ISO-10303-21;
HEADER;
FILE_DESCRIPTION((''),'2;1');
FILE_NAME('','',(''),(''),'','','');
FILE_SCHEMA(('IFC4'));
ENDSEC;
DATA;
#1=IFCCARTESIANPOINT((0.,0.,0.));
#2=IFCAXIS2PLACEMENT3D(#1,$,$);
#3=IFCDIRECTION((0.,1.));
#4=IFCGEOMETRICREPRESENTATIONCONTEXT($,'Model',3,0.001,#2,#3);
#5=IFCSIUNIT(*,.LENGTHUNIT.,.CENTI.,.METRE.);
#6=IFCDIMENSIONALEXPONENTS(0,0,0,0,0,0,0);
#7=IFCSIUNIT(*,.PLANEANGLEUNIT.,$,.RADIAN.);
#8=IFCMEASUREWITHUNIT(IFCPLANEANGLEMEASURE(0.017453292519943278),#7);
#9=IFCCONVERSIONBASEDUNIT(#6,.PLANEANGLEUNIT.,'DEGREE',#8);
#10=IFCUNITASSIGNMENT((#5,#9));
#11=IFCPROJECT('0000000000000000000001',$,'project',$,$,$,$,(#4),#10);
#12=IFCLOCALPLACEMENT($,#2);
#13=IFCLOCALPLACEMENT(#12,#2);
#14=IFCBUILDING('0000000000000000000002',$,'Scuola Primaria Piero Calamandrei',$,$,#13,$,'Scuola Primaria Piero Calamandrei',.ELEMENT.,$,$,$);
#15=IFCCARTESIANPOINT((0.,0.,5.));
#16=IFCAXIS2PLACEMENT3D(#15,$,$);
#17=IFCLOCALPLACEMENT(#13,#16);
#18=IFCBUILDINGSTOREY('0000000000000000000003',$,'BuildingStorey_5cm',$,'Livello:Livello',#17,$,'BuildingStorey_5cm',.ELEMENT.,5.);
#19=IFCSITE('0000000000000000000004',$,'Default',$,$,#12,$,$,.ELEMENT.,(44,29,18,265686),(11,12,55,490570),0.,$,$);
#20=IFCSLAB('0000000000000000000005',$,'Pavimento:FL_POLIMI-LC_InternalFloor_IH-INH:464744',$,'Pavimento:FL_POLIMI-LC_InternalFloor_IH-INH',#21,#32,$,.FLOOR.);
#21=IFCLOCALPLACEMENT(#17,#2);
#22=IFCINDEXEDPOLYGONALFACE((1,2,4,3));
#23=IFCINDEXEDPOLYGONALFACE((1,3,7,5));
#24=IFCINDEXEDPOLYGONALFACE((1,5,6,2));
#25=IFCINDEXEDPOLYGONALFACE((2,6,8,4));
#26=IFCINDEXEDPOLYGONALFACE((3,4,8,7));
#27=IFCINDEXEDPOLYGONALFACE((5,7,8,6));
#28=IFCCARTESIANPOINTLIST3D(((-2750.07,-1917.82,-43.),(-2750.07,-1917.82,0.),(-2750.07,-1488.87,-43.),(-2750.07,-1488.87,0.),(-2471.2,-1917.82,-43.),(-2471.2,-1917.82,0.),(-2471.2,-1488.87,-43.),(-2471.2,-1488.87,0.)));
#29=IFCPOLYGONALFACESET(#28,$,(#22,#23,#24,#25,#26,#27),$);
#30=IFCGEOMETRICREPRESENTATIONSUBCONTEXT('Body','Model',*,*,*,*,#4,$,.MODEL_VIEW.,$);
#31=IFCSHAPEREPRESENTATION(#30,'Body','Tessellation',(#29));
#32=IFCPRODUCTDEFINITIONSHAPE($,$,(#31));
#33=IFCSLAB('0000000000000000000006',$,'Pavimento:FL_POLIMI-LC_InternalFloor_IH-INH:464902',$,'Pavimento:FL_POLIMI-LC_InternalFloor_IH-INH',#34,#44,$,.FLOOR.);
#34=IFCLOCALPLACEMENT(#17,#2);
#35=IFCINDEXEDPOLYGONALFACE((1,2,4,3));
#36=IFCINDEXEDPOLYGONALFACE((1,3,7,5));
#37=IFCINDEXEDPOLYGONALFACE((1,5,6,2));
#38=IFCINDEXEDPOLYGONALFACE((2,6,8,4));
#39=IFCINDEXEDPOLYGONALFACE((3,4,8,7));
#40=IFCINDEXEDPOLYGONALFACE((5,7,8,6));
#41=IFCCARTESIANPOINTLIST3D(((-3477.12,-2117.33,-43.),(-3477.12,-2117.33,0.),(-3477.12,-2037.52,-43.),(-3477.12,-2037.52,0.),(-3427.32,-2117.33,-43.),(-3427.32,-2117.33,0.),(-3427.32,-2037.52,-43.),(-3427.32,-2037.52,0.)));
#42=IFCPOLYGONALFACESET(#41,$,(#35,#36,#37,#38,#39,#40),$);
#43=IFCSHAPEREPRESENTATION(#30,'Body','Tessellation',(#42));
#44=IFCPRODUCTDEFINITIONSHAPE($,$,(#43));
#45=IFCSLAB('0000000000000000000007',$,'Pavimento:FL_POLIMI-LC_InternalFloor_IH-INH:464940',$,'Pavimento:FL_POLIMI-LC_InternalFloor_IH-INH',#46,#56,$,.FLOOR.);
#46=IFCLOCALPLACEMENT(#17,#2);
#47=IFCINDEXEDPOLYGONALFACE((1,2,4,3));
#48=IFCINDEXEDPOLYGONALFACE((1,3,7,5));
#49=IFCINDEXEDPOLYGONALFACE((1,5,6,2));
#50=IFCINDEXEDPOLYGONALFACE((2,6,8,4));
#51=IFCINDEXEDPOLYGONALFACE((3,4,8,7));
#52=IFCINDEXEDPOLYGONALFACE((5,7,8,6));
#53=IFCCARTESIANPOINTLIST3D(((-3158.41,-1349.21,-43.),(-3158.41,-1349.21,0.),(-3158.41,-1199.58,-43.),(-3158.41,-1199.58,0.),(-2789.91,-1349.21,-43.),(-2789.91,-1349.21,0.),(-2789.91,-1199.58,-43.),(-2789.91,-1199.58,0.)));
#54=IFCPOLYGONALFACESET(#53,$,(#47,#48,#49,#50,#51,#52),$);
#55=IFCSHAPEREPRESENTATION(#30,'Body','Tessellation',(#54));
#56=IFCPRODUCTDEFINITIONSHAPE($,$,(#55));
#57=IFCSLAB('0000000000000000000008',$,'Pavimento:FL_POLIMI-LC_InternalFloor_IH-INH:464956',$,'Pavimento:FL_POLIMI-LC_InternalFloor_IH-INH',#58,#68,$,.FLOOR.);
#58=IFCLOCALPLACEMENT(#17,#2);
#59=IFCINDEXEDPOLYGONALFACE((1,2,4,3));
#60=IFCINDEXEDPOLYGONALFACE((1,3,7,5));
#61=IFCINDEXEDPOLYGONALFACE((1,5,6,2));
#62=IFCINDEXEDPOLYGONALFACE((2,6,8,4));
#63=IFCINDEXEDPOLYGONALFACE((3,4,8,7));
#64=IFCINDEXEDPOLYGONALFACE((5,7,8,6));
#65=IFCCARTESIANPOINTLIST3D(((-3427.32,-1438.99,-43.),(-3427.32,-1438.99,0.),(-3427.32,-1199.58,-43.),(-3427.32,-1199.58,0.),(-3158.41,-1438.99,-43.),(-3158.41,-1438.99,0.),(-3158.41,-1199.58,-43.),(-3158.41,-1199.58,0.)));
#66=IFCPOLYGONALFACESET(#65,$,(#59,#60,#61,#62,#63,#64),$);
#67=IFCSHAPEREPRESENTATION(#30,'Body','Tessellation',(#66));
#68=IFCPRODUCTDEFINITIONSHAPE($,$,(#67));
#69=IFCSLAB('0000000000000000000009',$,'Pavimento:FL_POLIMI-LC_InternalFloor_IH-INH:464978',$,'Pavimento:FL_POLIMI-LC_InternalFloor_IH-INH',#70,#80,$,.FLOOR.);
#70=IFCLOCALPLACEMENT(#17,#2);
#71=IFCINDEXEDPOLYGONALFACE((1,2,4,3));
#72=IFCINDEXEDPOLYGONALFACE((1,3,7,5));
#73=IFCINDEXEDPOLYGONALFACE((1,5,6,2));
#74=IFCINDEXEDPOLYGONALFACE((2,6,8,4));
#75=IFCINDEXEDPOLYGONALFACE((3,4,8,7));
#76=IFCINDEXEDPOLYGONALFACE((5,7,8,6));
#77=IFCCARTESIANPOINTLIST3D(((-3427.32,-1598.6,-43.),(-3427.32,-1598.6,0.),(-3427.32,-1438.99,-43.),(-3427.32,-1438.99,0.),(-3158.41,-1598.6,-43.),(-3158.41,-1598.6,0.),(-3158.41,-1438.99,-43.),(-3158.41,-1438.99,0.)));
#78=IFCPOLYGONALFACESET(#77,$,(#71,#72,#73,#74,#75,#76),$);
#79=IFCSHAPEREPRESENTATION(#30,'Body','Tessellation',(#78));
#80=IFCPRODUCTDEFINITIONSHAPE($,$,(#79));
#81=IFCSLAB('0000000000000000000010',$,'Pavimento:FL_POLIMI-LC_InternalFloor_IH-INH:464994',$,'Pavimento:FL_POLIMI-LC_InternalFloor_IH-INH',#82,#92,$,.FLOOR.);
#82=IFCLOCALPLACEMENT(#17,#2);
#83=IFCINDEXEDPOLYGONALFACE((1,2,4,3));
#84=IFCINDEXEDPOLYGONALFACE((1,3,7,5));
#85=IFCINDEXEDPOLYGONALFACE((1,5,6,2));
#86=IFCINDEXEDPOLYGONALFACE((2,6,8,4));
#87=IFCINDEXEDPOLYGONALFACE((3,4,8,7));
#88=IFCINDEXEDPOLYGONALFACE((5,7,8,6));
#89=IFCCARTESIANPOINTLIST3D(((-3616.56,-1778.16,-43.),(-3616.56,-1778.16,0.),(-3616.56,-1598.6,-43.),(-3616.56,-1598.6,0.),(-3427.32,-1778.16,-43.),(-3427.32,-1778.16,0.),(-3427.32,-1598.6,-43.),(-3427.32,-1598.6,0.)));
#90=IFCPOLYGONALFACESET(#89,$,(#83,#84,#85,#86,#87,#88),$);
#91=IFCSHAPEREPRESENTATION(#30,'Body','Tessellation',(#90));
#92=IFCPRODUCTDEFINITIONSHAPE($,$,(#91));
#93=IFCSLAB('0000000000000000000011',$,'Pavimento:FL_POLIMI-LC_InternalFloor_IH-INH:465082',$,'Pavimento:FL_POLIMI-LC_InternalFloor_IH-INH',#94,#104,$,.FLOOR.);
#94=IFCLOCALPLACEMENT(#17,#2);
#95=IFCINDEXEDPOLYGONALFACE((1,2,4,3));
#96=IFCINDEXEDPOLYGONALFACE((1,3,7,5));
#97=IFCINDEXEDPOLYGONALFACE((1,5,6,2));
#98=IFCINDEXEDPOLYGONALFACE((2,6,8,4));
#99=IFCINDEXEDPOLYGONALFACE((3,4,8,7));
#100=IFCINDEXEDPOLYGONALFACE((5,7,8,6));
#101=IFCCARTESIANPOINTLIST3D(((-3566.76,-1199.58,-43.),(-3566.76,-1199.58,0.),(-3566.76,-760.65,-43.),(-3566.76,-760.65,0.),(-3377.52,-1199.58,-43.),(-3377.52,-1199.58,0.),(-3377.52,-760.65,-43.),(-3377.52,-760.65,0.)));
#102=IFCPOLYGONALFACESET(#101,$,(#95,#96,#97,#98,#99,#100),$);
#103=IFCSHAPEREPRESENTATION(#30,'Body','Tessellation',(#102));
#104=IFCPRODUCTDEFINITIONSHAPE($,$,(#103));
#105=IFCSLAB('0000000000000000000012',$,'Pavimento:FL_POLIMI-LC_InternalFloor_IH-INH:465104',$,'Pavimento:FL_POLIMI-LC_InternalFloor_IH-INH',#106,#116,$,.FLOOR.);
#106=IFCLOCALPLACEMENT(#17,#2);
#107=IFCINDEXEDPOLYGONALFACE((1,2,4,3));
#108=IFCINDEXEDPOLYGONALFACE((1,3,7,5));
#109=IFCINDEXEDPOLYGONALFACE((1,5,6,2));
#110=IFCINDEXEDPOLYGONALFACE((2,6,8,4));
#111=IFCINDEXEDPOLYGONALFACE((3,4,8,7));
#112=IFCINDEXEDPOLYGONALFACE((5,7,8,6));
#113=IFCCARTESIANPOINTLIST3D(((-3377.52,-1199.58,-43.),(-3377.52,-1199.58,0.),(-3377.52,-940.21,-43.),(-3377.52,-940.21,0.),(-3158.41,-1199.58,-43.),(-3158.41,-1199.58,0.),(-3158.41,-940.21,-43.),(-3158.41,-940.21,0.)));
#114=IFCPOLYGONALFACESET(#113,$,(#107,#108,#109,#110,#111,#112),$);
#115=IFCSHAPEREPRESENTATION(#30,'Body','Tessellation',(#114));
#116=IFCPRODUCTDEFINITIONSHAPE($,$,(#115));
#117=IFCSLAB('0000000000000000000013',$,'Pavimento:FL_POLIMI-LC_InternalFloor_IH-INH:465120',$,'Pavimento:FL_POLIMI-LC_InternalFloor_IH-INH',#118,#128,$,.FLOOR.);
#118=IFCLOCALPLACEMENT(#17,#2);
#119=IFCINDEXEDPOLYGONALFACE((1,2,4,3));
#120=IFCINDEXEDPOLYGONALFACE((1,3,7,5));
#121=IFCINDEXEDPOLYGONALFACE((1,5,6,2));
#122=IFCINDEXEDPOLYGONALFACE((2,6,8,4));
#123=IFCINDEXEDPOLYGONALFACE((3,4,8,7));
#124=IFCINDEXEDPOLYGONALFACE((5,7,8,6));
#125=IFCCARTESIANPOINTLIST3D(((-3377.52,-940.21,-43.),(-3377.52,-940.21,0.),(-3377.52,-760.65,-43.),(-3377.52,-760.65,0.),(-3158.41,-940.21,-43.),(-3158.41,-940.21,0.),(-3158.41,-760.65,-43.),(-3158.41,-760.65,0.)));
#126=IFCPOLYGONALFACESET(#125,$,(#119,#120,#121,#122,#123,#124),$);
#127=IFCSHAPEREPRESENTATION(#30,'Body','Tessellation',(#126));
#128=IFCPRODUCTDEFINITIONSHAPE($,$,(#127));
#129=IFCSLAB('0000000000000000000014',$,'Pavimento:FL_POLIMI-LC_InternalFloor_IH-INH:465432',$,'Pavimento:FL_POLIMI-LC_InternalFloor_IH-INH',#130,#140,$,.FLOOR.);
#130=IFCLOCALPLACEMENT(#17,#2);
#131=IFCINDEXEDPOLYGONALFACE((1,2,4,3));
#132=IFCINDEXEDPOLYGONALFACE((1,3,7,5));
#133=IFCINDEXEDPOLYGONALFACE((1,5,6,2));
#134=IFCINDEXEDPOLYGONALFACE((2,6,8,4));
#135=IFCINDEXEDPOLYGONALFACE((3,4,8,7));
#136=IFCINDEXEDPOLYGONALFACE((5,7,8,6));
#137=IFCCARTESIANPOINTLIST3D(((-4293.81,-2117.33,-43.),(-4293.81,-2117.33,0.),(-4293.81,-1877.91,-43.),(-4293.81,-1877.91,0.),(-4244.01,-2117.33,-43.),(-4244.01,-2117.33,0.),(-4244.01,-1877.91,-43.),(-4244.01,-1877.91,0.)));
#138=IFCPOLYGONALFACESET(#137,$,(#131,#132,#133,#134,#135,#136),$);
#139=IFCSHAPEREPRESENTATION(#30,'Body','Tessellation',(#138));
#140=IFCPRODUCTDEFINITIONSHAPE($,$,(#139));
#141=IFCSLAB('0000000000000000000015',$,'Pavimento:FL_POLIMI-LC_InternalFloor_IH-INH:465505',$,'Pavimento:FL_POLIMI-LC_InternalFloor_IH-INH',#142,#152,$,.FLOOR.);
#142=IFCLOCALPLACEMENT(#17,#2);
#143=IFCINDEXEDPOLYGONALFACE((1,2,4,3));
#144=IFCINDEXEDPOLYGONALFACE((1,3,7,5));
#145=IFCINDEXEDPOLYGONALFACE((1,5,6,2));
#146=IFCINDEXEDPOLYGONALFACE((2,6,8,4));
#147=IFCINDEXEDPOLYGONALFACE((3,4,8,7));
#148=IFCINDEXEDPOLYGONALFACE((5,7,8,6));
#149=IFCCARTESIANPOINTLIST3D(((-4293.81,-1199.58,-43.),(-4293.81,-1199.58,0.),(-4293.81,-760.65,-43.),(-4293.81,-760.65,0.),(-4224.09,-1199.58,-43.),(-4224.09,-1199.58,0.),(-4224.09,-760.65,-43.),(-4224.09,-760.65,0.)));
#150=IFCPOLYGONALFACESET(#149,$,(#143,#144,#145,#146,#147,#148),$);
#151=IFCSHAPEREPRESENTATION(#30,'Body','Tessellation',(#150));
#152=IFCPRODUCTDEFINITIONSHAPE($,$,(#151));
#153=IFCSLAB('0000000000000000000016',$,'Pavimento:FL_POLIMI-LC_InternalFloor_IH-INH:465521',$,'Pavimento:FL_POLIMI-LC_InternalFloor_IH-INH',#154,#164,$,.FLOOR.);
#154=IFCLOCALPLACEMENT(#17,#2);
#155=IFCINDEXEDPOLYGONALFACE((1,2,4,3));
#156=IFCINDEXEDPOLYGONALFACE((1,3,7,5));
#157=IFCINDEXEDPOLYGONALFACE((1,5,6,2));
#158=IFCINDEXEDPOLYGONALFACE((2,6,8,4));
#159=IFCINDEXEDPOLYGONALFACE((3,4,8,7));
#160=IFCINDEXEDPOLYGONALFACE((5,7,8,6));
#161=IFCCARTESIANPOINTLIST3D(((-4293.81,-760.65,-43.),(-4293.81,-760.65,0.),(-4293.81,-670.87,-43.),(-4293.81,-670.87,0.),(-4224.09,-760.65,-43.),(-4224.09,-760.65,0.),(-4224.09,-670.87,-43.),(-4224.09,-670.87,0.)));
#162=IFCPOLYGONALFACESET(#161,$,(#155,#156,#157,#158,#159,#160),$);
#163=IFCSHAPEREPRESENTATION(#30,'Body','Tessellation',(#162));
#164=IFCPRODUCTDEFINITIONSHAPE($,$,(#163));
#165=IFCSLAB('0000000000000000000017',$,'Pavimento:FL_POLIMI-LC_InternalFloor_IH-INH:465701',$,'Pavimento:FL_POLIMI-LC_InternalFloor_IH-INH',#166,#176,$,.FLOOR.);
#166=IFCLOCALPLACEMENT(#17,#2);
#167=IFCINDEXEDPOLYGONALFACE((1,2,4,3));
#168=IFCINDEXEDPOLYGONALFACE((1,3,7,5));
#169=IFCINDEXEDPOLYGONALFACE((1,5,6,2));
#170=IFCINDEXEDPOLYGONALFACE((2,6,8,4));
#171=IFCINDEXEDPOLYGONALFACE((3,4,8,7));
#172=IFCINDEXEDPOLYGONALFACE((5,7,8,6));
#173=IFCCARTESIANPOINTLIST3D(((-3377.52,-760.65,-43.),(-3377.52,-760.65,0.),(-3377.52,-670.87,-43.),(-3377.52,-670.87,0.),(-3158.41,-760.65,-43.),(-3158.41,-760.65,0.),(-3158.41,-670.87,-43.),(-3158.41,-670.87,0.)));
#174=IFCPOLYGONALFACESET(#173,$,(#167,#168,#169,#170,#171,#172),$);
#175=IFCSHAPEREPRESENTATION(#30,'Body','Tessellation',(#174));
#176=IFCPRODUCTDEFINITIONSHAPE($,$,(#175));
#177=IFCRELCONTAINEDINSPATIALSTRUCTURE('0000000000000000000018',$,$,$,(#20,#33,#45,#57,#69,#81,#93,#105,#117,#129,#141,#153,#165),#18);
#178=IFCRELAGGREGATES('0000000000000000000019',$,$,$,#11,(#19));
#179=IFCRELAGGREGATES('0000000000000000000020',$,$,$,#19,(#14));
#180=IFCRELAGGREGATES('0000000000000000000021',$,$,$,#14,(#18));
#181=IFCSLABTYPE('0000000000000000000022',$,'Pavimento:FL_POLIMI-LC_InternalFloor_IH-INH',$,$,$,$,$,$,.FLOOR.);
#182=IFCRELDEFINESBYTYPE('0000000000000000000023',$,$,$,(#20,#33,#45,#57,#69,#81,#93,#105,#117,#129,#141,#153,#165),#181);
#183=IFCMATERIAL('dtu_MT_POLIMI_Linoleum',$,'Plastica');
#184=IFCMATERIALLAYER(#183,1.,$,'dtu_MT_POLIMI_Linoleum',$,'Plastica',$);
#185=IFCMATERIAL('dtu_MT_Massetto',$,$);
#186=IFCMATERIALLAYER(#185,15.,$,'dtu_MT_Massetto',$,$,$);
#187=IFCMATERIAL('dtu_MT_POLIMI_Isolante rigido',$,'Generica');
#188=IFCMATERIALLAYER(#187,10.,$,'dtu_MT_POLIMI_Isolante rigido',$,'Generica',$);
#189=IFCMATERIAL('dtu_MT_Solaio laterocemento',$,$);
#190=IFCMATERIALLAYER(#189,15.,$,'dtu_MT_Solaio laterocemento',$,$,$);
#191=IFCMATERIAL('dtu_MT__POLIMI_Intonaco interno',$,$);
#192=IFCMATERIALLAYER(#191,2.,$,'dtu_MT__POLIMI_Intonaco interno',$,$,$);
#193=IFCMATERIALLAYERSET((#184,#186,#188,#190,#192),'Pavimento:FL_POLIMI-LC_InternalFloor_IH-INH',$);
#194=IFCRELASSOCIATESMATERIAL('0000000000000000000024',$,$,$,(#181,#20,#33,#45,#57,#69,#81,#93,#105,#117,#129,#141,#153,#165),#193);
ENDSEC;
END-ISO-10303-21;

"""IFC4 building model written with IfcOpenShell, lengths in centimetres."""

from ifc_helpers import new_model, entity, si_unit, converted_unit, direction, frame, frame_2d, origin, origin_2d_with_axis, place, context, subcontext, project, spatial, rectangle, extrude, material, layer, layer_set, layer_usage, type_object, element, save


model = new_model("IFC4")

# Units and contexts
model_context = context("Model", 3, precision=0.001, world=origin(), true_north=direction((0.0, 1.0)))
body_context = subcontext(model_context, "Body", "Model", "MODEL_VIEW")
ifc_project = project(units=[si_unit("LENGTHUNIT", "METRE", prefix="CENTI"), converted_unit("PLANEANGLEUNIT", "DEGREE", entity("IfcPlaneAngleMeasure", 0.017453292519943278), si_unit("PLANEANGLEUNIT", "RADIAN"), dimensions=[0, 0, 0, 0, 0, 0, 0])], contexts=[model_context])

# Site, building, storey
site_placement = place(None, origin())
site = spatial("IfcSite", under=ifc_project, at=site_placement, Name="Default", CompositionType="ELEMENT", RefLatitude=(44, 29, 18, 265686), RefLongitude=(11, 12, 55, 490570), RefElevation=0.0)
building_placement = place(site_placement, origin())
building = spatial("IfcBuilding", under=site, at=building_placement, Name="Scuola Primaria Piero Calamandrei", LongName="Scuola Primaria Piero Calamandrei", CompositionType="ELEMENT")
storey_placement = place(building_placement, frame((0.0, 0.0, 5.0)))
storey = spatial("IfcBuildingStorey", under=building, at=storey_placement, Name="BuildingStorey_5cm", ObjectType="Livello:Livello", LongName="BuildingStorey_5cm", CompositionType="ELEMENT", Elevation=5.0)

# Slabs
ifc_material_1 = material(Name="dtu_MT_POLIMI_Linoleum", Category="Plastica")
ifc_layer_1 = layer(ifc_material_1, 1.0, Name="dtu_MT_POLIMI_Linoleum", Category="Plastica")
ifc_material_2 = material(Name="dtu_MT_Massetto")
ifc_layer_2 = layer(ifc_material_2, 15.0, Name="dtu_MT_Massetto")
ifc_material_3 = material(Name="dtu_MT_POLIMI_Isolante rigido", Category="Generica")
ifc_layer_3 = layer(ifc_material_3, 10.0, Name="dtu_MT_POLIMI_Isolante rigido", Category="Generica")
ifc_material_4 = material(Name="dtu_MT_Solaio laterocemento")
ifc_layer_4 = layer(ifc_material_4, 15.0, Name="dtu_MT_Solaio laterocemento")
ifc_material_5 = material(Name="dtu_MT__POLIMI_Intonaco interno")
ifc_layer_5 = layer(ifc_material_5, 2.0, Name="dtu_MT__POLIMI_Intonaco interno")
ifc_layer_set_1 = layer_set([ifc_layer_1, ifc_layer_2, ifc_layer_3, ifc_layer_4, ifc_layer_5], Name="Pavimento:FL_POLIMI-LC_InternalFloor_IH-INH")
ifc_layer_usage_1 = layer_usage(ifc_layer_set_1, "AXIS3", "POSITIVE", 0.0)
slab_type_1 = type_object("IfcSlabType", Name="Pavimento:FL_POLIMI-LC_InternalFloor_IH-INH", PredefinedType="FLOOR", material=ifc_layer_set_1)
slab_1_placement = place(storey_placement, origin())
element("IfcSlab", 1, at=slab_1_placement, inside=storey, type_object=slab_type_1, material=ifc_layer_usage_1, Name="Pavimento:FL_POLIMI-LC_InternalFloor_IH-INH:464744", ObjectType="Pavimento:FL_POLIMI-LC_InternalFloor_IH-INH", PredefinedType="FLOOR", context=body_context, shape_type="SweptSolid", body=[
    extrude(rectangle(XDim=428.95, YDim=278.87, at=frame_2d((0.0, 0.0), x_axis=(1.0, 0.0))), frame((-2610.63, -1703.34, 0.0), z_axis=(0.0, 0.0, -1.0), x_axis=(0.0, 1.0, 0.0)), (0.0, 0.0, 1.0), 43.0),
])
ifc_layer_usage_2 = layer_usage(ifc_layer_set_1, "AXIS3", "POSITIVE", 0.0)
slab_2_placement = place(storey_placement, origin())
element("IfcSlab", 2, at=slab_2_placement, inside=storey, type_object=slab_type_1, material=ifc_layer_usage_2, Name="Pavimento:FL_POLIMI-LC_InternalFloor_IH-INH:464902", ObjectType="Pavimento:FL_POLIMI-LC_InternalFloor_IH-INH", PredefinedType="FLOOR", context=body_context, shape_type="SweptSolid", body=[
    extrude(rectangle(XDim=79.8, YDim=49.8, at=frame_2d((0.0, 0.0), x_axis=(1.0, 0.0))), frame((-3452.22, -2077.42, 0.0), z_axis=(0.0, 0.0, -1.0), x_axis=(0.0, 1.0, 0.0)), (0.0, 0.0, 1.0), 43.0),
])
ifc_layer_usage_3 = layer_usage(ifc_layer_set_1, "AXIS3", "POSITIVE", 0.0)
slab_3_placement = place(storey_placement, origin())
element("IfcSlab", 3, at=slab_3_placement, inside=storey, type_object=slab_type_1, material=ifc_layer_usage_3, Name="Pavimento:FL_POLIMI-LC_InternalFloor_IH-INH:464940", ObjectType="Pavimento:FL_POLIMI-LC_InternalFloor_IH-INH", PredefinedType="FLOOR", context=body_context, shape_type="SweptSolid", body=[
    extrude(rectangle(XDim=149.63, YDim=368.51, at=frame_2d((0.0, 0.0), x_axis=(1.0, 0.0))), frame((-2974.16, -1274.39, 0.0), z_axis=(0.0, 0.0, -1.0), x_axis=(0.0, 1.0, 0.0)), (0.0, 0.0, 1.0), 43.0),
])
ifc_layer_usage_4 = layer_usage(ifc_layer_set_1, "AXIS3", "POSITIVE", 0.0)
slab_4_placement = place(storey_placement, origin())
element("IfcSlab", 4, at=slab_4_placement, inside=storey, type_object=slab_type_1, material=ifc_layer_usage_4, Name="Pavimento:FL_POLIMI-LC_InternalFloor_IH-INH:464956", ObjectType="Pavimento:FL_POLIMI-LC_InternalFloor_IH-INH", PredefinedType="FLOOR", context=body_context, shape_type="SweptSolid", body=[
    extrude(rectangle(XDim=239.41, YDim=268.91, at=origin_2d_with_axis()), frame((-3292.87, -1319.28, 0.0), z_axis=(0.0, 0.0, -1.0), x_axis=(0.0, 1.0, 0.0)), (0.0, 0.0, 1.0), 43.0),
])
ifc_layer_usage_5 = layer_usage(ifc_layer_set_1, "AXIS3", "POSITIVE", 0.0)
slab_5_placement = place(storey_placement, origin())
element("IfcSlab", 5, at=slab_5_placement, inside=storey, type_object=slab_type_1, material=ifc_layer_usage_5, Name="Pavimento:FL_POLIMI-LC_InternalFloor_IH-INH:464978", ObjectType="Pavimento:FL_POLIMI-LC_InternalFloor_IH-INH", PredefinedType="FLOOR", context=body_context, shape_type="SweptSolid", body=[
    extrude(rectangle(XDim=159.61, YDim=268.91, at=frame_2d((0.0, 0.0), x_axis=(1.0, 0.0))), frame((-3292.87, -1518.79, 0.0), z_axis=(0.0, 0.0, -1.0), x_axis=(0.0, 1.0, 0.0)), (0.0, 0.0, 1.0), 43.0),
])
ifc_layer_usage_6 = layer_usage(ifc_layer_set_1, "AXIS3", "POSITIVE", 0.0)
slab_6_placement = place(storey_placement, origin())
element("IfcSlab", 6, at=slab_6_placement, inside=storey, type_object=slab_type_1, material=ifc_layer_usage_6, Name="Pavimento:FL_POLIMI-LC_InternalFloor_IH-INH:464994", ObjectType="Pavimento:FL_POLIMI-LC_InternalFloor_IH-INH", PredefinedType="FLOOR", context=body_context, shape_type="SweptSolid", body=[
    extrude(rectangle(XDim=189.23, YDim=179.56, at=frame_2d((0.0, 0.0), x_axis=(1.0, 0.0))), frame((-3521.94, -1688.38, 0.0), z_axis=(0.0, 0.0, -1.0), x_axis=(1.0, 0.0, 0.0)), (0.0, 0.0, 1.0), 43.0),
])
ifc_layer_usage_7 = layer_usage(ifc_layer_set_1, "AXIS3", "POSITIVE", 0.0)
slab_7_placement = place(storey_placement, origin())
element("IfcSlab", 7, at=slab_7_placement, inside=storey, type_object=slab_type_1, material=ifc_layer_usage_7, Name="Pavimento:FL_POLIMI-LC_InternalFloor_IH-INH:465082", ObjectType="Pavimento:FL_POLIMI-LC_InternalFloor_IH-INH", PredefinedType="FLOOR", context=body_context, shape_type="SweptSolid", body=[
    extrude(rectangle(XDim=438.92, YDim=189.23, at=frame_2d((0.0, 0.0), x_axis=(1.0, 0.0))), frame((-3472.14, -980.11, 0.0), z_axis=(0.0, 0.0, -1.0), x_axis=(0.0, 1.0, 0.0)), (0.0, 0.0, 1.0), 43.0),
])
ifc_layer_usage_8 = layer_usage(ifc_layer_set_1, "AXIS3", "POSITIVE", 0.0)
slab_8_placement = place(storey_placement, origin())
element("IfcSlab", 8, at=slab_8_placement, inside=storey, type_object=slab_type_1, material=ifc_layer_usage_8, Name="Pavimento:FL_POLIMI-LC_InternalFloor_IH-INH:465104", ObjectType="Pavimento:FL_POLIMI-LC_InternalFloor_IH-INH", PredefinedType="FLOOR", context=body_context, shape_type="SweptSolid", body=[
    extrude(rectangle(XDim=259.36, YDim=219.11, at=frame_2d((0.0, 0.0), x_axis=(1.0, 0.0))), frame((-3267.97, -1069.89, 0.0), z_axis=(0.0, 0.0, -1.0), x_axis=(0.0, 1.0, 0.0)), (0.0, 0.0, 1.0), 43.0),
])
ifc_layer_usage_9 = layer_usage(ifc_layer_set_1, "AXIS3", "POSITIVE", 0.0)
slab_9_placement = place(storey_placement, origin())
element("IfcSlab", 9, at=slab_9_placement, inside=storey, type_object=slab_type_1, material=ifc_layer_usage_9, Name="Pavimento:FL_POLIMI-LC_InternalFloor_IH-INH:465120", ObjectType="Pavimento:FL_POLIMI-LC_InternalFloor_IH-INH", PredefinedType="FLOOR", context=body_context, shape_type="SweptSolid", body=[
    extrude(rectangle(XDim=179.56, YDim=219.11, at=frame_2d((0.0, 0.0), x_axis=(1.0, 0.0))), frame((-3267.97, -850.43, 0.0), z_axis=(0.0, 0.0, -1.0), x_axis=(0.0, 1.0, 0.0)), (0.0, 0.0, 1.0), 43.0),
])
ifc_layer_usage_10 = layer_usage(ifc_layer_set_1, "AXIS3", "POSITIVE", 0.0)
slab_10_placement = place(storey_placement, origin())
element("IfcSlab", 10, at=slab_10_placement, inside=storey, type_object=slab_type_1, material=ifc_layer_usage_10, Name="Pavimento:FL_POLIMI-LC_InternalFloor_IH-INH:465432", ObjectType="Pavimento:FL_POLIMI-LC_InternalFloor_IH-INH", PredefinedType="FLOOR", context=body_context, shape_type="SweptSolid", body=[
    extrude(rectangle(XDim=239.41, YDim=49.8, at=frame_2d((0.0, 0.0), x_axis=(1.0, 0.0))), frame((-4268.91, -1997.62, 0.0), z_axis=(0.0, 0.0, -1.0), x_axis=(0.0, 1.0, 0.0)), (0.0, 0.0, 1.0), 43.0),
])
ifc_layer_usage_11 = layer_usage(ifc_layer_set_1, "AXIS3", "POSITIVE", 0.0)
slab_11_placement = place(storey_placement, origin())
element("IfcSlab", 11, at=slab_11_placement, inside=storey, type_object=slab_type_1, material=ifc_layer_usage_11, Name="Pavimento:FL_POLIMI-LC_InternalFloor_IH-INH:465505", ObjectType="Pavimento:FL_POLIMI-LC_InternalFloor_IH-INH", PredefinedType="FLOOR", context=body_context, shape_type="SweptSolid", body=[
    extrude(rectangle(XDim=438.92, YDim=69.72, at=frame_2d((0.0, 0.0), x_axis=(1.0, 0.0))), frame((-4258.95, -980.11, 0.0), z_axis=(0.0, 0.0, -1.0), x_axis=(0.0, 1.0, 0.0)), (0.0, 0.0, 1.0), 43.0),
])
ifc_layer_usage_12 = layer_usage(ifc_layer_set_1, "AXIS3", "POSITIVE", 0.0)
slab_12_placement = place(storey_placement, origin())
element("IfcSlab", 12, at=slab_12_placement, inside=storey, type_object=slab_type_1, material=ifc_layer_usage_12, Name="Pavimento:FL_POLIMI-LC_InternalFloor_IH-INH:465521", ObjectType="Pavimento:FL_POLIMI-LC_InternalFloor_IH-INH", PredefinedType="FLOOR", context=body_context, shape_type="SweptSolid", body=[
    extrude(rectangle(XDim=89.78, YDim=69.72, at=origin_2d_with_axis()), frame((-4258.95, -715.76, 0.0), z_axis=(0.0, 0.0, -1.0), x_axis=(0.0, 1.0, 0.0)), (0.0, 0.0, 1.0), 43.0),
])
ifc_layer_usage_13 = layer_usage(ifc_layer_set_1, "AXIS3", "POSITIVE", 0.0)
slab_13_placement = place(storey_placement, origin())
element("IfcSlab", 13, at=slab_13_placement, inside=storey, type_object=slab_type_1, material=ifc_layer_usage_13, Name="Pavimento:FL_POLIMI-LC_InternalFloor_IH-INH:465701", ObjectType="Pavimento:FL_POLIMI-LC_InternalFloor_IH-INH", PredefinedType="FLOOR", context=body_context, shape_type="SweptSolid", body=[
    extrude(rectangle(XDim=89.78, YDim=219.11, at=frame_2d((0.0, 0.0), x_axis=(1.0, 0.0))), frame((-3267.97, -715.76, 0.0), z_axis=(0.0, 0.0, -1.0), x_axis=(0.0, 1.0, 0.0)), (0.0, 0.0, 1.0), 43.0),
])

save(model, "model.ifc")
